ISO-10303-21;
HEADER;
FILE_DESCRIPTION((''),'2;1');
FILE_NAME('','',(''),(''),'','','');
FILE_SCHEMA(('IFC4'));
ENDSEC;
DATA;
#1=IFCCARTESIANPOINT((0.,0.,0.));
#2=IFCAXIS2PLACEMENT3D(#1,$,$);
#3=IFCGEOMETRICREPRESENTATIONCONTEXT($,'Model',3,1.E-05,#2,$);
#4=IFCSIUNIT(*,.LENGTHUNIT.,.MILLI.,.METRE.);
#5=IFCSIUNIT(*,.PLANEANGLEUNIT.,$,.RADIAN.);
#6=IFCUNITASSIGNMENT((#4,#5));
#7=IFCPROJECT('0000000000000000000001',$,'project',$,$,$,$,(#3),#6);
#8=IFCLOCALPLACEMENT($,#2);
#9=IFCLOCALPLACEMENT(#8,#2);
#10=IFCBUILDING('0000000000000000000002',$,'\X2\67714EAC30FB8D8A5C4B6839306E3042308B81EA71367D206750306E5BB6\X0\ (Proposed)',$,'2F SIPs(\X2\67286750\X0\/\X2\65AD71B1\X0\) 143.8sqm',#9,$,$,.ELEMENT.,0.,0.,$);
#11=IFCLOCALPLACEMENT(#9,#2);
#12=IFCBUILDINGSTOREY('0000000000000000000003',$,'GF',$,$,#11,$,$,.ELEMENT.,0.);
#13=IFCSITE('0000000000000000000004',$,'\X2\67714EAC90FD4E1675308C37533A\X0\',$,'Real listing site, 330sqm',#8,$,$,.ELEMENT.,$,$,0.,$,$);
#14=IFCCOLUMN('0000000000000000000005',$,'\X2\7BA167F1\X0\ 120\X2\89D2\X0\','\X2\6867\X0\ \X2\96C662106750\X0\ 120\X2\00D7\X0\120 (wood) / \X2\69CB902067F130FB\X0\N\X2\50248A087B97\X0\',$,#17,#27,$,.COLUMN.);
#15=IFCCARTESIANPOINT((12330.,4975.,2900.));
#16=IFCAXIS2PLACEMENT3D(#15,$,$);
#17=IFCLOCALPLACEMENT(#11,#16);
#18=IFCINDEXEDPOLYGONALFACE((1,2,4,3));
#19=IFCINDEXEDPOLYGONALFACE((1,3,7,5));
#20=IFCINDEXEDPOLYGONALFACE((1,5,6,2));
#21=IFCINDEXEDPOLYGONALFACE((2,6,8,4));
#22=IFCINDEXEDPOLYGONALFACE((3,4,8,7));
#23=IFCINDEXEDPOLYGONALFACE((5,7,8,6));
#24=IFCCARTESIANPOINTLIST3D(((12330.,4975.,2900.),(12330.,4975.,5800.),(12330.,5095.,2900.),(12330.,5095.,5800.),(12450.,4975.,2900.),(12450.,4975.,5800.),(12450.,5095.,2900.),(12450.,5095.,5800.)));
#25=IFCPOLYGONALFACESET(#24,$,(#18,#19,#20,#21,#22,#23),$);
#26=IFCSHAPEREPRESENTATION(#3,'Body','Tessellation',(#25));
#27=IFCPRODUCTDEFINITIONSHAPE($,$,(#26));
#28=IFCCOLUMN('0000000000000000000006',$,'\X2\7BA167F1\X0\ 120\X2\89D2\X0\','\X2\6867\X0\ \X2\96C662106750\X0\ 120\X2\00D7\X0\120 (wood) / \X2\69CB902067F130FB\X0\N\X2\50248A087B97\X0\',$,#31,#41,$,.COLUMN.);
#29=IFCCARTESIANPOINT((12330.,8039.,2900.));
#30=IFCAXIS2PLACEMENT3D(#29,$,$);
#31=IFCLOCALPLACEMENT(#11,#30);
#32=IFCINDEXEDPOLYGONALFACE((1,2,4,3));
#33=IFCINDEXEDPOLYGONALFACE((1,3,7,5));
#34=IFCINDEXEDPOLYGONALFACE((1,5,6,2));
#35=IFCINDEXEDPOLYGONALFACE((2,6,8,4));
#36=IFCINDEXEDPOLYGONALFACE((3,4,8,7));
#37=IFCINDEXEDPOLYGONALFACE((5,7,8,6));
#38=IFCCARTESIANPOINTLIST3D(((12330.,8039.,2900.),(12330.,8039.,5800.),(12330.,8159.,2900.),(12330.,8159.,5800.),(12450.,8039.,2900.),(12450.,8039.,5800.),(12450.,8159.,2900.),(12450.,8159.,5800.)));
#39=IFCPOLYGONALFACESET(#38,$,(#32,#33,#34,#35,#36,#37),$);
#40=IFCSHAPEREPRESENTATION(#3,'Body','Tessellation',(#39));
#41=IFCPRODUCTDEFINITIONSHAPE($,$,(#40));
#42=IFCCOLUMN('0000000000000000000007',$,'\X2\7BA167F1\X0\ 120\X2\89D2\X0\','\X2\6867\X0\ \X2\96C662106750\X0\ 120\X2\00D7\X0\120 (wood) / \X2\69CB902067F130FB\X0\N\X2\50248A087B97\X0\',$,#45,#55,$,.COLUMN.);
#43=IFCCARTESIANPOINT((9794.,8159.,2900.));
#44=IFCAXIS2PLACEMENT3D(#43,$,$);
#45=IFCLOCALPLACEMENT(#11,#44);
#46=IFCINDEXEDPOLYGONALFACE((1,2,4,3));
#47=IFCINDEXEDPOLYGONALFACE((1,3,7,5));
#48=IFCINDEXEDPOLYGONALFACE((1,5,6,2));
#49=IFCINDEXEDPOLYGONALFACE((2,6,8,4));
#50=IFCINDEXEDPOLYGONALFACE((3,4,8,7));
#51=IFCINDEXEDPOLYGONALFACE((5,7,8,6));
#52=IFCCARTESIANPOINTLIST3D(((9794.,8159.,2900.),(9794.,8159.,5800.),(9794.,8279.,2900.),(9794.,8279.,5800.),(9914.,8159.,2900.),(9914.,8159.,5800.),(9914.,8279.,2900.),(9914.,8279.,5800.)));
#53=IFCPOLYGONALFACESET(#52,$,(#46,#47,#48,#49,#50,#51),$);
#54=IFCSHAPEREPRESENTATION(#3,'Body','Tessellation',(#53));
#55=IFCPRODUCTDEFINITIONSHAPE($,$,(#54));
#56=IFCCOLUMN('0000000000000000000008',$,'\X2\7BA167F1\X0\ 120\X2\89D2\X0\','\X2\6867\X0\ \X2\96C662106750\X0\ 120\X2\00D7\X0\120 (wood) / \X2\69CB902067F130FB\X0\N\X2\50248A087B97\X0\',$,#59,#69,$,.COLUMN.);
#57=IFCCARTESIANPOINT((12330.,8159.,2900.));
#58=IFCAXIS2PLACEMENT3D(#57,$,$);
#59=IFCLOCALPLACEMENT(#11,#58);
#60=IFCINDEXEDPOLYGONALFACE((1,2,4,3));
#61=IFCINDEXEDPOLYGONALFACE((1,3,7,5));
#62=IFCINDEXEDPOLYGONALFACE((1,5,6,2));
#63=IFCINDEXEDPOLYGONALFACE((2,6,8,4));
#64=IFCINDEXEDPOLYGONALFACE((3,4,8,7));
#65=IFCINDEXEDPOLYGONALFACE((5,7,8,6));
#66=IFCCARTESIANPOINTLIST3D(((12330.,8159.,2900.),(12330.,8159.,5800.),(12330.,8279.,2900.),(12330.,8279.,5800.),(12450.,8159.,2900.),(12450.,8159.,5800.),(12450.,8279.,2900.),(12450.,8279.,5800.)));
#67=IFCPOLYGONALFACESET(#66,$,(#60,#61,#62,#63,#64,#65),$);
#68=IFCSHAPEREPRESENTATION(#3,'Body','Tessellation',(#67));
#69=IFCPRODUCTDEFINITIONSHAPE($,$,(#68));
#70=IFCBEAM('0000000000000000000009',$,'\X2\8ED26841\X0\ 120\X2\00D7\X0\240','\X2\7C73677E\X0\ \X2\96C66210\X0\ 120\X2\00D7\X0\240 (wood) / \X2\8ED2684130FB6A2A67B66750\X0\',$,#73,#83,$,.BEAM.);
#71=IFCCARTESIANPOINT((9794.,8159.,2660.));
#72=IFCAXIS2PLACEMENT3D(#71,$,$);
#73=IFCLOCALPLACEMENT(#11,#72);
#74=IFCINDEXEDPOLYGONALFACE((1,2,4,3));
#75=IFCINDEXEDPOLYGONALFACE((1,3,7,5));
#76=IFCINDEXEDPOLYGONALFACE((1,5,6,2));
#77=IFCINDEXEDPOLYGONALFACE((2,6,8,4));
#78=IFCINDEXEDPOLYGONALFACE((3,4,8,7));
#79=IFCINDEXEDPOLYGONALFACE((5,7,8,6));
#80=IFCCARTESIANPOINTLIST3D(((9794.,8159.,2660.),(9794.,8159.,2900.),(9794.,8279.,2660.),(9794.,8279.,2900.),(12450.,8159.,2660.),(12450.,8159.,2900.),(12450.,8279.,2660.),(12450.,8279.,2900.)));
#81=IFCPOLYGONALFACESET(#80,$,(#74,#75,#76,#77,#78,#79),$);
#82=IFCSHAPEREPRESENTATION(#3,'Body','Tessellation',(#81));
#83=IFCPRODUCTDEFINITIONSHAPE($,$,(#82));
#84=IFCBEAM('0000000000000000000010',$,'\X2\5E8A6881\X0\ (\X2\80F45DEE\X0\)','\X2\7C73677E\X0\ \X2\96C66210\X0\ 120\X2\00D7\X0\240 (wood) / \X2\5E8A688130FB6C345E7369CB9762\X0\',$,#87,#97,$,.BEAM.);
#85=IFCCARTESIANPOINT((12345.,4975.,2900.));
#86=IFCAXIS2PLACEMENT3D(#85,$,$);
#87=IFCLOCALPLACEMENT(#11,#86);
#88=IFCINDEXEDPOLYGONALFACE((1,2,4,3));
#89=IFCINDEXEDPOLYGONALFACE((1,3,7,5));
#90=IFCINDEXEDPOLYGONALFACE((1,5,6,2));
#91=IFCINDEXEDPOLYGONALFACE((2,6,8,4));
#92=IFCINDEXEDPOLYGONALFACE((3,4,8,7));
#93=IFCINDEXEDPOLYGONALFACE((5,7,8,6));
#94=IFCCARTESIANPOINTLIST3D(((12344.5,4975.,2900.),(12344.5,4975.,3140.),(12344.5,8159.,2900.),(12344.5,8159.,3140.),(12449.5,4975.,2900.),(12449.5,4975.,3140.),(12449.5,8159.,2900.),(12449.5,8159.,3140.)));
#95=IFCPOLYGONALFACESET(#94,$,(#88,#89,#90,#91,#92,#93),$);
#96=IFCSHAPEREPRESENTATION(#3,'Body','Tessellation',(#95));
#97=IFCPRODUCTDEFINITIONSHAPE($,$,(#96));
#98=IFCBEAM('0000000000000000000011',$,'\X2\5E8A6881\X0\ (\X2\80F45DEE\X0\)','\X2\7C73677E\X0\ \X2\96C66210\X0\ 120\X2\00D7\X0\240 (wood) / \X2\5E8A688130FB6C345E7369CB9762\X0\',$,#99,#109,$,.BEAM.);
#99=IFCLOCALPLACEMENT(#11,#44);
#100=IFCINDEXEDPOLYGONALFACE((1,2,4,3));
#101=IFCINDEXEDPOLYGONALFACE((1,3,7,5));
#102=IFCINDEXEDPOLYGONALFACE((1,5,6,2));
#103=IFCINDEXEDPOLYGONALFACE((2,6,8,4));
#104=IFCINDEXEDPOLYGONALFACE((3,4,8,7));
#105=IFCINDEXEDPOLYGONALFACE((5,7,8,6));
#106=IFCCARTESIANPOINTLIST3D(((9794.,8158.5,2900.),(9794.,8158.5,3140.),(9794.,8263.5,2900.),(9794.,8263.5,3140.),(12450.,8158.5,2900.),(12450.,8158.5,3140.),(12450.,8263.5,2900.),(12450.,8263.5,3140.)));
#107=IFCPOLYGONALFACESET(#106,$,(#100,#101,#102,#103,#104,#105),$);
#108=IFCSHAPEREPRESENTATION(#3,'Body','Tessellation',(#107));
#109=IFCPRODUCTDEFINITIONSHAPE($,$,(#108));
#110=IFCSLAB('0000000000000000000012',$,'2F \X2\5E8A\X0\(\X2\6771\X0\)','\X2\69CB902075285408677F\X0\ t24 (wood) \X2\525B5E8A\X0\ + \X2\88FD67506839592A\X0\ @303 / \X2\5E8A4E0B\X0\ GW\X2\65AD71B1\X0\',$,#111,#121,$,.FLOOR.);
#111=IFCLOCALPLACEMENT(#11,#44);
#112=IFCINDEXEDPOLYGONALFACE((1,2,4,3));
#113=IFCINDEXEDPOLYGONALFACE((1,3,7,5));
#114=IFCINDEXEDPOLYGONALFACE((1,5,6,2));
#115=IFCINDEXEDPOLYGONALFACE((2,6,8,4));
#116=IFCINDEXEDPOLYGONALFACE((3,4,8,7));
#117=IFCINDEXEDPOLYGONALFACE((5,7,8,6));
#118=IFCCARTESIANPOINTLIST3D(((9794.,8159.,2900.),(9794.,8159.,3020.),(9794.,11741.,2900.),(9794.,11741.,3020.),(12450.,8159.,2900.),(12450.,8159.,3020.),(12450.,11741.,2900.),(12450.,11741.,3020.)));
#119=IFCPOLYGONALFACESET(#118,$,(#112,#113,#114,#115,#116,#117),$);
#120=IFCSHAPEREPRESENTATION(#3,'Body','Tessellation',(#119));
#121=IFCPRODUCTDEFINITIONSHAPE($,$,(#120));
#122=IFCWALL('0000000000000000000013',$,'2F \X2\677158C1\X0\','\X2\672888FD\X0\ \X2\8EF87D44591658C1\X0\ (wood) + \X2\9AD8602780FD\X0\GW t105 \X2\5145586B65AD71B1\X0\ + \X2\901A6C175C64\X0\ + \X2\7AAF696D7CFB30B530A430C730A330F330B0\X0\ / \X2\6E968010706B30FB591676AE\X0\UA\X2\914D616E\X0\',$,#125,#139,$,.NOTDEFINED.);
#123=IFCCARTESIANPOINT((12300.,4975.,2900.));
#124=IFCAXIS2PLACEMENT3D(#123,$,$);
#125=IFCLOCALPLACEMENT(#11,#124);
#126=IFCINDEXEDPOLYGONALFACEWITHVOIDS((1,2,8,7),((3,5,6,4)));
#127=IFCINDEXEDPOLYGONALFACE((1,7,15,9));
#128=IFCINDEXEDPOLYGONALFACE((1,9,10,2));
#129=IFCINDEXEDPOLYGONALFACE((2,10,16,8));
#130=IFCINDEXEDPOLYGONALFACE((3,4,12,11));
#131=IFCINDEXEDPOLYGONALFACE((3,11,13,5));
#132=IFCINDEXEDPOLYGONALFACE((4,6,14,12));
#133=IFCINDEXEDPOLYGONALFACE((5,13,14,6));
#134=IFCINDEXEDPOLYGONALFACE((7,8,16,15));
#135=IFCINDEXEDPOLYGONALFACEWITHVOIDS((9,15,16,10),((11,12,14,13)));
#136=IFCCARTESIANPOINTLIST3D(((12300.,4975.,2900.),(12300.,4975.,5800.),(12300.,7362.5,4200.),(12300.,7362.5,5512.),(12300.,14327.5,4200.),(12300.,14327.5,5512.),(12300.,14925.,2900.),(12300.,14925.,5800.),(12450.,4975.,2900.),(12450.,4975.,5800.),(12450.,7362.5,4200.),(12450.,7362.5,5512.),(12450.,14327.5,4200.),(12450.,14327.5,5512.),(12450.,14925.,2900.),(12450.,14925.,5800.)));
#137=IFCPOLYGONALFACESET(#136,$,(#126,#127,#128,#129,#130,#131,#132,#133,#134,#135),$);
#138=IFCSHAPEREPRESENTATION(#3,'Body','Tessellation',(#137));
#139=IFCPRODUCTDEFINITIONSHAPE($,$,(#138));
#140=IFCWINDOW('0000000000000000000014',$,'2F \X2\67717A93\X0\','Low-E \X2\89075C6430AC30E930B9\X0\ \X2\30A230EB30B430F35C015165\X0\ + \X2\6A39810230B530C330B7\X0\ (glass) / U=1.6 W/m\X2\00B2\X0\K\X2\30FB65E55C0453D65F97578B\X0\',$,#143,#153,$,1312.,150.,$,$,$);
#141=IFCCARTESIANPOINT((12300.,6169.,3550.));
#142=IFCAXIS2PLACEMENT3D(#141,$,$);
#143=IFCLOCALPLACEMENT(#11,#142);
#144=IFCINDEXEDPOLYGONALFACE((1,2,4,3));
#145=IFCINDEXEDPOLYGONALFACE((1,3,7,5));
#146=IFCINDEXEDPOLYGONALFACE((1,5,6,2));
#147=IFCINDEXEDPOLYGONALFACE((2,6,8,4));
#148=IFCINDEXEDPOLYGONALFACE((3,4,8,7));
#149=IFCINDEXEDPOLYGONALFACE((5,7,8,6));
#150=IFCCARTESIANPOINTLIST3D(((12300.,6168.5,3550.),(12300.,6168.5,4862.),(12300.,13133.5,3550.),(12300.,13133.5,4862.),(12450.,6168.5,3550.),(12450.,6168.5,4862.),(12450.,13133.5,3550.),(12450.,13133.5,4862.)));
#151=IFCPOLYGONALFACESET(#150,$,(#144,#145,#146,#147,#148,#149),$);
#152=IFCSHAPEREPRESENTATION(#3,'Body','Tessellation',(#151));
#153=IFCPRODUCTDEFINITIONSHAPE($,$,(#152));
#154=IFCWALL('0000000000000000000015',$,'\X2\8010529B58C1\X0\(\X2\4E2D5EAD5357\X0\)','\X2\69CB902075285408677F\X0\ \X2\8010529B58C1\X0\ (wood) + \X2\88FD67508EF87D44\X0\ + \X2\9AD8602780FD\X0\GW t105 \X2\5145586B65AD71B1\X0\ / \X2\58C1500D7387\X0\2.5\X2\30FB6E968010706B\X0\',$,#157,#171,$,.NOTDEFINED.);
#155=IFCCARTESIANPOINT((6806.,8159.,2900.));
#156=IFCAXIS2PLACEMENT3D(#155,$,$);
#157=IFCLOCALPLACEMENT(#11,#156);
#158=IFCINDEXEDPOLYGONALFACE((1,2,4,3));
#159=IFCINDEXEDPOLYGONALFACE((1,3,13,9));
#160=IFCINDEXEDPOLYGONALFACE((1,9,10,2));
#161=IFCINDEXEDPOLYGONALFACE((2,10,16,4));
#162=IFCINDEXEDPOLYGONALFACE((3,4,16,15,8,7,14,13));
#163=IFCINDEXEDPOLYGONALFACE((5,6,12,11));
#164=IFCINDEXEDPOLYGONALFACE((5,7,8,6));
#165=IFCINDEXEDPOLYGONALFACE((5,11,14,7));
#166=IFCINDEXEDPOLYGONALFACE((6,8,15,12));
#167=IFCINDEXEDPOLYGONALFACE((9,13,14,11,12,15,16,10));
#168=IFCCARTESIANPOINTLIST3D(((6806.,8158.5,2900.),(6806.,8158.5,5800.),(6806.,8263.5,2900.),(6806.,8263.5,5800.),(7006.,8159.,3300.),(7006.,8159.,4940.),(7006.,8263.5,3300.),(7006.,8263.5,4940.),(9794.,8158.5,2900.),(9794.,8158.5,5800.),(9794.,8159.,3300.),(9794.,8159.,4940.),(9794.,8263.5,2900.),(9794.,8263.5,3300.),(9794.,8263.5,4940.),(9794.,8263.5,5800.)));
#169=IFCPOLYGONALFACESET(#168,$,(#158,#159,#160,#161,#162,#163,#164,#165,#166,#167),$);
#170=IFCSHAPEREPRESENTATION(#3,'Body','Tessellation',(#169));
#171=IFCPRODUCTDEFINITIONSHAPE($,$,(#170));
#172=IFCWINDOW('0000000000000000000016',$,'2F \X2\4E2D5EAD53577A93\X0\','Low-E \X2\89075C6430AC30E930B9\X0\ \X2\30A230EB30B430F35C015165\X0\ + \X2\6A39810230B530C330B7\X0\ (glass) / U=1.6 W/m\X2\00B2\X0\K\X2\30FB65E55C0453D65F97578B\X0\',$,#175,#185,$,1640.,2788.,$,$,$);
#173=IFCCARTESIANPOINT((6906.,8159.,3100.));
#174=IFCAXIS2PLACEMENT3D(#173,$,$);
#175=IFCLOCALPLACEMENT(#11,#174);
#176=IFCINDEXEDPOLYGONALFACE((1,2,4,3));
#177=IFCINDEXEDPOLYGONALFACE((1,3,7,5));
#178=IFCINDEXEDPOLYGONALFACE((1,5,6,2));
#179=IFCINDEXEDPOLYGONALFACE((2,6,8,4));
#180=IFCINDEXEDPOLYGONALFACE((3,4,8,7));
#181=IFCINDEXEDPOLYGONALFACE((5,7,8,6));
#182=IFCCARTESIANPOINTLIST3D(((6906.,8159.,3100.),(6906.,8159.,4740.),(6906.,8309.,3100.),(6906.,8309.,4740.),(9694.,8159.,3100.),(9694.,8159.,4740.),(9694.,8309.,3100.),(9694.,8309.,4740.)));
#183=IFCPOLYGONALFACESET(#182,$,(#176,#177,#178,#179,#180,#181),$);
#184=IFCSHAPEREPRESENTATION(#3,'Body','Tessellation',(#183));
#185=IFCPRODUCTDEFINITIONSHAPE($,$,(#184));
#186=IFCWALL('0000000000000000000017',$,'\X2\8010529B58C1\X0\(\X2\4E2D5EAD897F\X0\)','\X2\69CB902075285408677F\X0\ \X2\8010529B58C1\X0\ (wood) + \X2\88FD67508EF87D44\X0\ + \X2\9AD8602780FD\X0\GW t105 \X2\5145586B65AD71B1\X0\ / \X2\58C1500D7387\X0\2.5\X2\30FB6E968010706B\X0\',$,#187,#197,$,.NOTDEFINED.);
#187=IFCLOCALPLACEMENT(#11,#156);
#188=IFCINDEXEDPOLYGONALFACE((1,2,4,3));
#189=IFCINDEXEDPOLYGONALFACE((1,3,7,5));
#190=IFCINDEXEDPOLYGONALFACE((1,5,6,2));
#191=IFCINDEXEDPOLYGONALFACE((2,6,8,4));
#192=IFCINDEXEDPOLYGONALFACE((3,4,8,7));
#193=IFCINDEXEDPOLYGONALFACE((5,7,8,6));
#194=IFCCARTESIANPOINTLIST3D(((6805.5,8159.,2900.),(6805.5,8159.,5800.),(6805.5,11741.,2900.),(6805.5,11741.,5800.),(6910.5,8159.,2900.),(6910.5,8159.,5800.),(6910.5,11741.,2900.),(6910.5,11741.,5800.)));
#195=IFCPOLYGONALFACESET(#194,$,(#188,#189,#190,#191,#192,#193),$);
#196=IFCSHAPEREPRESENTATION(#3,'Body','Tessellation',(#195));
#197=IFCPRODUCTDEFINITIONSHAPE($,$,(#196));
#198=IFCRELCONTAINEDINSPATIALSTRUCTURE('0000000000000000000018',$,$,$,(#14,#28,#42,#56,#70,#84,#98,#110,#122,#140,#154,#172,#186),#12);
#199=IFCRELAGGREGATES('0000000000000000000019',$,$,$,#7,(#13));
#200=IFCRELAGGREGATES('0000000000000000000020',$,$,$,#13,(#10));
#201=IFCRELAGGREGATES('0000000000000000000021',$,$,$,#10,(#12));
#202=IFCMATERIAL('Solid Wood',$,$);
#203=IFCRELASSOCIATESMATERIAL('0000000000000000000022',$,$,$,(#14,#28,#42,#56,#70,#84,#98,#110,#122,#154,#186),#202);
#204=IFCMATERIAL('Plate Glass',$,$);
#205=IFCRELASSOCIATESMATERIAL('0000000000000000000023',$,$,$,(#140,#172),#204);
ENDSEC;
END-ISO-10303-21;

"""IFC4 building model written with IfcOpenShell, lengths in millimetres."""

from ifc_helpers import new_model, si_unit, frame, frame_2d, origin, place, context, project, spatial, rectangle, extrude, material, element, fill, save


model = new_model("IFC4")

# Units and contexts
model_context = context("Model", 3, precision=1e-05, world=origin())
ifc_project = project(units=[si_unit("LENGTHUNIT", "METRE", prefix="MILLI"), si_unit("PLANEANGLEUNIT", "RADIAN")], contexts=[model_context])

# Site, building, storey
site_placement = place(None, origin())
site = spatial("IfcSite", under=ifc_project, at=site_placement, Name="東京都世田谷区", ObjectType="Real listing site, 330sqm", CompositionType="ELEMENT", RefElevation=0.0)
building_placement = place(site_placement, origin())
building = spatial("IfcBuilding", under=site, at=building_placement, Name="東京・越屋根のある自然素材の家 (Proposed)", ObjectType="2F SIPs(木材/断熱) 143.8sqm", CompositionType="ELEMENT", ElevationOfRefHeight=0.0, ElevationOfTerrain=0.0)
storey_placement = place(building_placement, origin())
storey = spatial("IfcBuildingStorey", under=building, at=storey_placement, Name="GF", CompositionType="ELEMENT", Elevation=0.0)

# Columns
ifc_material_1 = material(Name="Solid Wood")
column_1_placement = place(storey_placement, frame((12330.0, 4975.0, 2900.0)))
element("IfcColumn", 1, at=column_1_placement, inside=storey, material=ifc_material_1, Name="管柱 120角", Description="桧 集成材 120×120 (wood) / 構造柱・N値計算", PredefinedType="COLUMN", context=model_context, shape_type="SweptSolid", body=[
    extrude(rectangle(XDim=120.0, YDim=120.0, at=frame_2d((60.0, 60.0))), frame((12330.0, 4975.0, 2900.0)), (0.0, 0.0, 1.0), 2900.0),
])
column_2_placement = place(storey_placement, frame((12330.0, 8039.0, 2900.0)))
element("IfcColumn", 2, at=column_2_placement, inside=storey, material=ifc_material_1, Name="管柱 120角", Description="桧 集成材 120×120 (wood) / 構造柱・N値計算", PredefinedType="COLUMN", context=model_context, shape_type="SweptSolid", body=[
    extrude(rectangle(XDim=120.0, YDim=120.0, at=frame_2d((60.0, 60.0))), frame((12330.0, 8039.0, 2900.0)), (0.0, 0.0, 1.0), 2900.0),
])
column_3_placement = place(storey_placement, frame((9794.0, 8159.0, 2900.0)))
element("IfcColumn", 3, at=column_3_placement, inside=storey, material=ifc_material_1, Name="管柱 120角", Description="桧 集成材 120×120 (wood) / 構造柱・N値計算", PredefinedType="COLUMN", context=model_context, shape_type="SweptSolid", body=[
    extrude(rectangle(XDim=120.0, YDim=120.0, at=frame_2d((60.0, 60.0))), frame((9794.0, 8159.0, 2900.0)), (0.0, 0.0, 1.0), 2900.0),
])
column_4_placement = place(storey_placement, frame((12330.0, 8159.0, 2900.0)))
element("IfcColumn", 4, at=column_4_placement, inside=storey, material=ifc_material_1, Name="管柱 120角", Description="桧 集成材 120×120 (wood) / 構造柱・N値計算", PredefinedType="COLUMN", context=model_context, shape_type="SweptSolid", body=[
    extrude(rectangle(XDim=120.0, YDim=120.0, at=frame_2d((60.0, 60.0))), frame((12330.0, 8159.0, 2900.0)), (0.0, 0.0, 1.0), 2900.0),
])

# Beams
beam_1_placement = place(storey_placement, frame((9794.0, 8159.0, 2660.0)))
element("IfcBeam", 5, at=beam_1_placement, inside=storey, material=ifc_material_1, Name="軒桁 120×240", Description="米松 集成 120×240 (wood) / 軒桁・横架材", PredefinedType="BEAM", context=model_context, shape_type="SweptSolid", body=[
    extrude(rectangle(XDim=2656.0, YDim=120.0, at=frame_2d((1328.0, 60.0))), frame((9794.0, 8159.0, 2660.0)), (0.0, 0.0, 1.0), 240.0),
])
beam_2_placement = place(storey_placement, frame((12345.0, 4975.0, 2900.0)))
element("IfcBeam", 6, at=beam_2_placement, inside=storey, material=ifc_material_1, Name="床梁 (胴差)", Description="米松 集成 120×240 (wood) / 床梁・水平構面", PredefinedType="BEAM", context=model_context, shape_type="SweptSolid", body=[
    extrude(rectangle(XDim=105.0, YDim=3184.0, at=frame_2d((52.0, 1592.0))), frame((12345.0, 4975.0, 2900.0)), (0.0, 0.0, 1.0), 240.0),
])
beam_3_placement = place(storey_placement, frame((9794.0, 8159.0, 2900.0)))
element("IfcBeam", 7, at=beam_3_placement, inside=storey, material=ifc_material_1, Name="床梁 (胴差)", Description="米松 集成 120×240 (wood) / 床梁・水平構面", PredefinedType="BEAM", context=model_context, shape_type="SweptSolid", body=[
    extrude(rectangle(XDim=2656.0, YDim=105.0, at=frame_2d((1328.0, 52.0))), frame((9794.0, 8159.0, 2900.0)), (0.0, 0.0, 1.0), 240.0),
])

# Slab
slab_placement = place(storey_placement, frame((9794.0, 8159.0, 2900.0)))
element("IfcSlab", 8, at=slab_placement, inside=storey, material=ifc_material_1, Name="2F 床(東)", Description="構造用合板 t24 (wood) 剛床 + 製材根太 @303 / 床下 GW断熱", PredefinedType="FLOOR", context=model_context, shape_type="SweptSolid", body=[
    extrude(rectangle(XDim=2656.0, YDim=3582.0, at=frame_2d((1328.0, 1791.0))), frame((9794.0, 8159.0, 2900.0)), (0.0, 0.0, 1.0), 120.0),
])

# Walls, openings, windows
wall_1_placement = place(storey_placement, frame((12300.0, 4975.0, 2900.0)))
wall_1 = element("IfcWall", 9, at=wall_1_placement, inside=storey, material=ifc_material_1, Name="2F 東壁", Description="木製 軸組外壁 (wood) + 高性能GW t105 充填断熱 + 通気層 + 窯業系サイディング / 準耐火・外皮UA配慮", PredefinedType="NOTDEFINED", context=model_context, shape_type="SweptSolid", body=[
    extrude(rectangle(XDim=150.0, YDim=9950.0, at=frame_2d((75.0, 4975.0))), frame((12300.0, 4975.0, 2900.0)), (0.0, 0.0, 1.0), 2900.0),
])
opening_1_placement = place(storey_placement, frame((12300.0, 6169.0, 3550.0)))
opening_1 = element("IfcOpeningElement", 10, at=opening_1_placement, cuts=wall_1, PredefinedType="NOTDEFINED", context=model_context, shape_type="SweptSolid", body=[
    extrude(rectangle(XDim=150.0, YDim=6965.0, at=frame_2d((75.0, 3482.0))), frame((12300.0, 6169.0, 3550.0)), (0.0, 0.0, 1.0), 1312.0),
])
ifc_material_2 = material(Name="Plate Glass")
window_1_placement = place(storey_placement, frame((12300.0, 6169.0, 3550.0)))
window_1 = element("IfcWindow", 11, at=window_1_placement, inside=storey, material=ifc_material_2, Name="2F 東窓", Description="Low-E 複層ガラス アルゴン封入 + 樹脂サッシ (glass) / U=1.6 W/m²K・日射取得型", OverallHeight=1312.0, OverallWidth=150.0, context=model_context, shape_type="SweptSolid", body=[
    extrude(rectangle(XDim=150.0, YDim=6965.0, at=frame_2d((75.0, 3482.0))), frame((12300.0, 6169.0, 3550.0)), (0.0, 0.0, 1.0), 1312.0),
])
fill(opening_1, window_1)
wall_2_placement = place(storey_placement, frame((6806.0, 8159.0, 2900.0)))
wall_2 = element("IfcWall", 12, at=wall_2_placement, inside=storey, material=ifc_material_1, Name="耐力壁(中庭南)", Description="構造用合板 耐力壁 (wood) + 製材軸組 + 高性能GW t105 充填断熱 / 壁倍率2.5・準耐火", PredefinedType="NOTDEFINED", context=model_context, shape_type="SweptSolid", body=[
    extrude(rectangle(XDim=2988.0, YDim=105.0, at=frame_2d((1494.0, 52.0))), frame((6806.0, 8159.0, 2900.0)), (0.0, 0.0, 1.0), 2900.0),
])
opening_2_placement = place(storey_placement, frame((6906.0, 8159.0, 3100.0)))
opening_2 = element("IfcOpeningElement", 13, at=opening_2_placement, cuts=wall_2, PredefinedType="NOTDEFINED", context=model_context, shape_type="SweptSolid", body=[
    extrude(rectangle(XDim=2788.0, YDim=150.0, at=frame_2d((1394.0, 75.0))), frame((6906.0, 8159.0, 3100.0)), (0.0, 0.0, 1.0), 1640.0),
])
window_2_placement = place(storey_placement, frame((6906.0, 8159.0, 3100.0)))
window_2 = element("IfcWindow", 14, at=window_2_placement, inside=storey, material=ifc_material_2, Name="2F 中庭南窓", Description="Low-E 複層ガラス アルゴン封入 + 樹脂サッシ (glass) / U=1.6 W/m²K・日射取得型", OverallHeight=1640.0, OverallWidth=2788.0, context=model_context, shape_type="SweptSolid", body=[
    extrude(rectangle(XDim=2788.0, YDim=150.0, at=frame_2d((1394.0, 75.0))), frame((6906.0, 8159.0, 3100.0)), (0.0, 0.0, 1.0), 1640.0),
])
fill(opening_2, window_2)

# Wall
wall_3_placement = place(storey_placement, frame((6806.0, 8159.0, 2900.0)))
element("IfcWall", 15, at=wall_3_placement, inside=storey, material=ifc_material_1, Name="耐力壁(中庭西)", Description="構造用合板 耐力壁 (wood) + 製材軸組 + 高性能GW t105 充填断熱 / 壁倍率2.5・準耐火", PredefinedType="NOTDEFINED", context=model_context, shape_type="SweptSolid", body=[
    extrude(rectangle(XDim=105.0, YDim=3582.0, at=frame_2d((52.0, 1791.0))), frame((6806.0, 8159.0, 2900.0)), (0.0, 0.0, 1.0), 2900.0),
])

save(model, "model.ifc")
